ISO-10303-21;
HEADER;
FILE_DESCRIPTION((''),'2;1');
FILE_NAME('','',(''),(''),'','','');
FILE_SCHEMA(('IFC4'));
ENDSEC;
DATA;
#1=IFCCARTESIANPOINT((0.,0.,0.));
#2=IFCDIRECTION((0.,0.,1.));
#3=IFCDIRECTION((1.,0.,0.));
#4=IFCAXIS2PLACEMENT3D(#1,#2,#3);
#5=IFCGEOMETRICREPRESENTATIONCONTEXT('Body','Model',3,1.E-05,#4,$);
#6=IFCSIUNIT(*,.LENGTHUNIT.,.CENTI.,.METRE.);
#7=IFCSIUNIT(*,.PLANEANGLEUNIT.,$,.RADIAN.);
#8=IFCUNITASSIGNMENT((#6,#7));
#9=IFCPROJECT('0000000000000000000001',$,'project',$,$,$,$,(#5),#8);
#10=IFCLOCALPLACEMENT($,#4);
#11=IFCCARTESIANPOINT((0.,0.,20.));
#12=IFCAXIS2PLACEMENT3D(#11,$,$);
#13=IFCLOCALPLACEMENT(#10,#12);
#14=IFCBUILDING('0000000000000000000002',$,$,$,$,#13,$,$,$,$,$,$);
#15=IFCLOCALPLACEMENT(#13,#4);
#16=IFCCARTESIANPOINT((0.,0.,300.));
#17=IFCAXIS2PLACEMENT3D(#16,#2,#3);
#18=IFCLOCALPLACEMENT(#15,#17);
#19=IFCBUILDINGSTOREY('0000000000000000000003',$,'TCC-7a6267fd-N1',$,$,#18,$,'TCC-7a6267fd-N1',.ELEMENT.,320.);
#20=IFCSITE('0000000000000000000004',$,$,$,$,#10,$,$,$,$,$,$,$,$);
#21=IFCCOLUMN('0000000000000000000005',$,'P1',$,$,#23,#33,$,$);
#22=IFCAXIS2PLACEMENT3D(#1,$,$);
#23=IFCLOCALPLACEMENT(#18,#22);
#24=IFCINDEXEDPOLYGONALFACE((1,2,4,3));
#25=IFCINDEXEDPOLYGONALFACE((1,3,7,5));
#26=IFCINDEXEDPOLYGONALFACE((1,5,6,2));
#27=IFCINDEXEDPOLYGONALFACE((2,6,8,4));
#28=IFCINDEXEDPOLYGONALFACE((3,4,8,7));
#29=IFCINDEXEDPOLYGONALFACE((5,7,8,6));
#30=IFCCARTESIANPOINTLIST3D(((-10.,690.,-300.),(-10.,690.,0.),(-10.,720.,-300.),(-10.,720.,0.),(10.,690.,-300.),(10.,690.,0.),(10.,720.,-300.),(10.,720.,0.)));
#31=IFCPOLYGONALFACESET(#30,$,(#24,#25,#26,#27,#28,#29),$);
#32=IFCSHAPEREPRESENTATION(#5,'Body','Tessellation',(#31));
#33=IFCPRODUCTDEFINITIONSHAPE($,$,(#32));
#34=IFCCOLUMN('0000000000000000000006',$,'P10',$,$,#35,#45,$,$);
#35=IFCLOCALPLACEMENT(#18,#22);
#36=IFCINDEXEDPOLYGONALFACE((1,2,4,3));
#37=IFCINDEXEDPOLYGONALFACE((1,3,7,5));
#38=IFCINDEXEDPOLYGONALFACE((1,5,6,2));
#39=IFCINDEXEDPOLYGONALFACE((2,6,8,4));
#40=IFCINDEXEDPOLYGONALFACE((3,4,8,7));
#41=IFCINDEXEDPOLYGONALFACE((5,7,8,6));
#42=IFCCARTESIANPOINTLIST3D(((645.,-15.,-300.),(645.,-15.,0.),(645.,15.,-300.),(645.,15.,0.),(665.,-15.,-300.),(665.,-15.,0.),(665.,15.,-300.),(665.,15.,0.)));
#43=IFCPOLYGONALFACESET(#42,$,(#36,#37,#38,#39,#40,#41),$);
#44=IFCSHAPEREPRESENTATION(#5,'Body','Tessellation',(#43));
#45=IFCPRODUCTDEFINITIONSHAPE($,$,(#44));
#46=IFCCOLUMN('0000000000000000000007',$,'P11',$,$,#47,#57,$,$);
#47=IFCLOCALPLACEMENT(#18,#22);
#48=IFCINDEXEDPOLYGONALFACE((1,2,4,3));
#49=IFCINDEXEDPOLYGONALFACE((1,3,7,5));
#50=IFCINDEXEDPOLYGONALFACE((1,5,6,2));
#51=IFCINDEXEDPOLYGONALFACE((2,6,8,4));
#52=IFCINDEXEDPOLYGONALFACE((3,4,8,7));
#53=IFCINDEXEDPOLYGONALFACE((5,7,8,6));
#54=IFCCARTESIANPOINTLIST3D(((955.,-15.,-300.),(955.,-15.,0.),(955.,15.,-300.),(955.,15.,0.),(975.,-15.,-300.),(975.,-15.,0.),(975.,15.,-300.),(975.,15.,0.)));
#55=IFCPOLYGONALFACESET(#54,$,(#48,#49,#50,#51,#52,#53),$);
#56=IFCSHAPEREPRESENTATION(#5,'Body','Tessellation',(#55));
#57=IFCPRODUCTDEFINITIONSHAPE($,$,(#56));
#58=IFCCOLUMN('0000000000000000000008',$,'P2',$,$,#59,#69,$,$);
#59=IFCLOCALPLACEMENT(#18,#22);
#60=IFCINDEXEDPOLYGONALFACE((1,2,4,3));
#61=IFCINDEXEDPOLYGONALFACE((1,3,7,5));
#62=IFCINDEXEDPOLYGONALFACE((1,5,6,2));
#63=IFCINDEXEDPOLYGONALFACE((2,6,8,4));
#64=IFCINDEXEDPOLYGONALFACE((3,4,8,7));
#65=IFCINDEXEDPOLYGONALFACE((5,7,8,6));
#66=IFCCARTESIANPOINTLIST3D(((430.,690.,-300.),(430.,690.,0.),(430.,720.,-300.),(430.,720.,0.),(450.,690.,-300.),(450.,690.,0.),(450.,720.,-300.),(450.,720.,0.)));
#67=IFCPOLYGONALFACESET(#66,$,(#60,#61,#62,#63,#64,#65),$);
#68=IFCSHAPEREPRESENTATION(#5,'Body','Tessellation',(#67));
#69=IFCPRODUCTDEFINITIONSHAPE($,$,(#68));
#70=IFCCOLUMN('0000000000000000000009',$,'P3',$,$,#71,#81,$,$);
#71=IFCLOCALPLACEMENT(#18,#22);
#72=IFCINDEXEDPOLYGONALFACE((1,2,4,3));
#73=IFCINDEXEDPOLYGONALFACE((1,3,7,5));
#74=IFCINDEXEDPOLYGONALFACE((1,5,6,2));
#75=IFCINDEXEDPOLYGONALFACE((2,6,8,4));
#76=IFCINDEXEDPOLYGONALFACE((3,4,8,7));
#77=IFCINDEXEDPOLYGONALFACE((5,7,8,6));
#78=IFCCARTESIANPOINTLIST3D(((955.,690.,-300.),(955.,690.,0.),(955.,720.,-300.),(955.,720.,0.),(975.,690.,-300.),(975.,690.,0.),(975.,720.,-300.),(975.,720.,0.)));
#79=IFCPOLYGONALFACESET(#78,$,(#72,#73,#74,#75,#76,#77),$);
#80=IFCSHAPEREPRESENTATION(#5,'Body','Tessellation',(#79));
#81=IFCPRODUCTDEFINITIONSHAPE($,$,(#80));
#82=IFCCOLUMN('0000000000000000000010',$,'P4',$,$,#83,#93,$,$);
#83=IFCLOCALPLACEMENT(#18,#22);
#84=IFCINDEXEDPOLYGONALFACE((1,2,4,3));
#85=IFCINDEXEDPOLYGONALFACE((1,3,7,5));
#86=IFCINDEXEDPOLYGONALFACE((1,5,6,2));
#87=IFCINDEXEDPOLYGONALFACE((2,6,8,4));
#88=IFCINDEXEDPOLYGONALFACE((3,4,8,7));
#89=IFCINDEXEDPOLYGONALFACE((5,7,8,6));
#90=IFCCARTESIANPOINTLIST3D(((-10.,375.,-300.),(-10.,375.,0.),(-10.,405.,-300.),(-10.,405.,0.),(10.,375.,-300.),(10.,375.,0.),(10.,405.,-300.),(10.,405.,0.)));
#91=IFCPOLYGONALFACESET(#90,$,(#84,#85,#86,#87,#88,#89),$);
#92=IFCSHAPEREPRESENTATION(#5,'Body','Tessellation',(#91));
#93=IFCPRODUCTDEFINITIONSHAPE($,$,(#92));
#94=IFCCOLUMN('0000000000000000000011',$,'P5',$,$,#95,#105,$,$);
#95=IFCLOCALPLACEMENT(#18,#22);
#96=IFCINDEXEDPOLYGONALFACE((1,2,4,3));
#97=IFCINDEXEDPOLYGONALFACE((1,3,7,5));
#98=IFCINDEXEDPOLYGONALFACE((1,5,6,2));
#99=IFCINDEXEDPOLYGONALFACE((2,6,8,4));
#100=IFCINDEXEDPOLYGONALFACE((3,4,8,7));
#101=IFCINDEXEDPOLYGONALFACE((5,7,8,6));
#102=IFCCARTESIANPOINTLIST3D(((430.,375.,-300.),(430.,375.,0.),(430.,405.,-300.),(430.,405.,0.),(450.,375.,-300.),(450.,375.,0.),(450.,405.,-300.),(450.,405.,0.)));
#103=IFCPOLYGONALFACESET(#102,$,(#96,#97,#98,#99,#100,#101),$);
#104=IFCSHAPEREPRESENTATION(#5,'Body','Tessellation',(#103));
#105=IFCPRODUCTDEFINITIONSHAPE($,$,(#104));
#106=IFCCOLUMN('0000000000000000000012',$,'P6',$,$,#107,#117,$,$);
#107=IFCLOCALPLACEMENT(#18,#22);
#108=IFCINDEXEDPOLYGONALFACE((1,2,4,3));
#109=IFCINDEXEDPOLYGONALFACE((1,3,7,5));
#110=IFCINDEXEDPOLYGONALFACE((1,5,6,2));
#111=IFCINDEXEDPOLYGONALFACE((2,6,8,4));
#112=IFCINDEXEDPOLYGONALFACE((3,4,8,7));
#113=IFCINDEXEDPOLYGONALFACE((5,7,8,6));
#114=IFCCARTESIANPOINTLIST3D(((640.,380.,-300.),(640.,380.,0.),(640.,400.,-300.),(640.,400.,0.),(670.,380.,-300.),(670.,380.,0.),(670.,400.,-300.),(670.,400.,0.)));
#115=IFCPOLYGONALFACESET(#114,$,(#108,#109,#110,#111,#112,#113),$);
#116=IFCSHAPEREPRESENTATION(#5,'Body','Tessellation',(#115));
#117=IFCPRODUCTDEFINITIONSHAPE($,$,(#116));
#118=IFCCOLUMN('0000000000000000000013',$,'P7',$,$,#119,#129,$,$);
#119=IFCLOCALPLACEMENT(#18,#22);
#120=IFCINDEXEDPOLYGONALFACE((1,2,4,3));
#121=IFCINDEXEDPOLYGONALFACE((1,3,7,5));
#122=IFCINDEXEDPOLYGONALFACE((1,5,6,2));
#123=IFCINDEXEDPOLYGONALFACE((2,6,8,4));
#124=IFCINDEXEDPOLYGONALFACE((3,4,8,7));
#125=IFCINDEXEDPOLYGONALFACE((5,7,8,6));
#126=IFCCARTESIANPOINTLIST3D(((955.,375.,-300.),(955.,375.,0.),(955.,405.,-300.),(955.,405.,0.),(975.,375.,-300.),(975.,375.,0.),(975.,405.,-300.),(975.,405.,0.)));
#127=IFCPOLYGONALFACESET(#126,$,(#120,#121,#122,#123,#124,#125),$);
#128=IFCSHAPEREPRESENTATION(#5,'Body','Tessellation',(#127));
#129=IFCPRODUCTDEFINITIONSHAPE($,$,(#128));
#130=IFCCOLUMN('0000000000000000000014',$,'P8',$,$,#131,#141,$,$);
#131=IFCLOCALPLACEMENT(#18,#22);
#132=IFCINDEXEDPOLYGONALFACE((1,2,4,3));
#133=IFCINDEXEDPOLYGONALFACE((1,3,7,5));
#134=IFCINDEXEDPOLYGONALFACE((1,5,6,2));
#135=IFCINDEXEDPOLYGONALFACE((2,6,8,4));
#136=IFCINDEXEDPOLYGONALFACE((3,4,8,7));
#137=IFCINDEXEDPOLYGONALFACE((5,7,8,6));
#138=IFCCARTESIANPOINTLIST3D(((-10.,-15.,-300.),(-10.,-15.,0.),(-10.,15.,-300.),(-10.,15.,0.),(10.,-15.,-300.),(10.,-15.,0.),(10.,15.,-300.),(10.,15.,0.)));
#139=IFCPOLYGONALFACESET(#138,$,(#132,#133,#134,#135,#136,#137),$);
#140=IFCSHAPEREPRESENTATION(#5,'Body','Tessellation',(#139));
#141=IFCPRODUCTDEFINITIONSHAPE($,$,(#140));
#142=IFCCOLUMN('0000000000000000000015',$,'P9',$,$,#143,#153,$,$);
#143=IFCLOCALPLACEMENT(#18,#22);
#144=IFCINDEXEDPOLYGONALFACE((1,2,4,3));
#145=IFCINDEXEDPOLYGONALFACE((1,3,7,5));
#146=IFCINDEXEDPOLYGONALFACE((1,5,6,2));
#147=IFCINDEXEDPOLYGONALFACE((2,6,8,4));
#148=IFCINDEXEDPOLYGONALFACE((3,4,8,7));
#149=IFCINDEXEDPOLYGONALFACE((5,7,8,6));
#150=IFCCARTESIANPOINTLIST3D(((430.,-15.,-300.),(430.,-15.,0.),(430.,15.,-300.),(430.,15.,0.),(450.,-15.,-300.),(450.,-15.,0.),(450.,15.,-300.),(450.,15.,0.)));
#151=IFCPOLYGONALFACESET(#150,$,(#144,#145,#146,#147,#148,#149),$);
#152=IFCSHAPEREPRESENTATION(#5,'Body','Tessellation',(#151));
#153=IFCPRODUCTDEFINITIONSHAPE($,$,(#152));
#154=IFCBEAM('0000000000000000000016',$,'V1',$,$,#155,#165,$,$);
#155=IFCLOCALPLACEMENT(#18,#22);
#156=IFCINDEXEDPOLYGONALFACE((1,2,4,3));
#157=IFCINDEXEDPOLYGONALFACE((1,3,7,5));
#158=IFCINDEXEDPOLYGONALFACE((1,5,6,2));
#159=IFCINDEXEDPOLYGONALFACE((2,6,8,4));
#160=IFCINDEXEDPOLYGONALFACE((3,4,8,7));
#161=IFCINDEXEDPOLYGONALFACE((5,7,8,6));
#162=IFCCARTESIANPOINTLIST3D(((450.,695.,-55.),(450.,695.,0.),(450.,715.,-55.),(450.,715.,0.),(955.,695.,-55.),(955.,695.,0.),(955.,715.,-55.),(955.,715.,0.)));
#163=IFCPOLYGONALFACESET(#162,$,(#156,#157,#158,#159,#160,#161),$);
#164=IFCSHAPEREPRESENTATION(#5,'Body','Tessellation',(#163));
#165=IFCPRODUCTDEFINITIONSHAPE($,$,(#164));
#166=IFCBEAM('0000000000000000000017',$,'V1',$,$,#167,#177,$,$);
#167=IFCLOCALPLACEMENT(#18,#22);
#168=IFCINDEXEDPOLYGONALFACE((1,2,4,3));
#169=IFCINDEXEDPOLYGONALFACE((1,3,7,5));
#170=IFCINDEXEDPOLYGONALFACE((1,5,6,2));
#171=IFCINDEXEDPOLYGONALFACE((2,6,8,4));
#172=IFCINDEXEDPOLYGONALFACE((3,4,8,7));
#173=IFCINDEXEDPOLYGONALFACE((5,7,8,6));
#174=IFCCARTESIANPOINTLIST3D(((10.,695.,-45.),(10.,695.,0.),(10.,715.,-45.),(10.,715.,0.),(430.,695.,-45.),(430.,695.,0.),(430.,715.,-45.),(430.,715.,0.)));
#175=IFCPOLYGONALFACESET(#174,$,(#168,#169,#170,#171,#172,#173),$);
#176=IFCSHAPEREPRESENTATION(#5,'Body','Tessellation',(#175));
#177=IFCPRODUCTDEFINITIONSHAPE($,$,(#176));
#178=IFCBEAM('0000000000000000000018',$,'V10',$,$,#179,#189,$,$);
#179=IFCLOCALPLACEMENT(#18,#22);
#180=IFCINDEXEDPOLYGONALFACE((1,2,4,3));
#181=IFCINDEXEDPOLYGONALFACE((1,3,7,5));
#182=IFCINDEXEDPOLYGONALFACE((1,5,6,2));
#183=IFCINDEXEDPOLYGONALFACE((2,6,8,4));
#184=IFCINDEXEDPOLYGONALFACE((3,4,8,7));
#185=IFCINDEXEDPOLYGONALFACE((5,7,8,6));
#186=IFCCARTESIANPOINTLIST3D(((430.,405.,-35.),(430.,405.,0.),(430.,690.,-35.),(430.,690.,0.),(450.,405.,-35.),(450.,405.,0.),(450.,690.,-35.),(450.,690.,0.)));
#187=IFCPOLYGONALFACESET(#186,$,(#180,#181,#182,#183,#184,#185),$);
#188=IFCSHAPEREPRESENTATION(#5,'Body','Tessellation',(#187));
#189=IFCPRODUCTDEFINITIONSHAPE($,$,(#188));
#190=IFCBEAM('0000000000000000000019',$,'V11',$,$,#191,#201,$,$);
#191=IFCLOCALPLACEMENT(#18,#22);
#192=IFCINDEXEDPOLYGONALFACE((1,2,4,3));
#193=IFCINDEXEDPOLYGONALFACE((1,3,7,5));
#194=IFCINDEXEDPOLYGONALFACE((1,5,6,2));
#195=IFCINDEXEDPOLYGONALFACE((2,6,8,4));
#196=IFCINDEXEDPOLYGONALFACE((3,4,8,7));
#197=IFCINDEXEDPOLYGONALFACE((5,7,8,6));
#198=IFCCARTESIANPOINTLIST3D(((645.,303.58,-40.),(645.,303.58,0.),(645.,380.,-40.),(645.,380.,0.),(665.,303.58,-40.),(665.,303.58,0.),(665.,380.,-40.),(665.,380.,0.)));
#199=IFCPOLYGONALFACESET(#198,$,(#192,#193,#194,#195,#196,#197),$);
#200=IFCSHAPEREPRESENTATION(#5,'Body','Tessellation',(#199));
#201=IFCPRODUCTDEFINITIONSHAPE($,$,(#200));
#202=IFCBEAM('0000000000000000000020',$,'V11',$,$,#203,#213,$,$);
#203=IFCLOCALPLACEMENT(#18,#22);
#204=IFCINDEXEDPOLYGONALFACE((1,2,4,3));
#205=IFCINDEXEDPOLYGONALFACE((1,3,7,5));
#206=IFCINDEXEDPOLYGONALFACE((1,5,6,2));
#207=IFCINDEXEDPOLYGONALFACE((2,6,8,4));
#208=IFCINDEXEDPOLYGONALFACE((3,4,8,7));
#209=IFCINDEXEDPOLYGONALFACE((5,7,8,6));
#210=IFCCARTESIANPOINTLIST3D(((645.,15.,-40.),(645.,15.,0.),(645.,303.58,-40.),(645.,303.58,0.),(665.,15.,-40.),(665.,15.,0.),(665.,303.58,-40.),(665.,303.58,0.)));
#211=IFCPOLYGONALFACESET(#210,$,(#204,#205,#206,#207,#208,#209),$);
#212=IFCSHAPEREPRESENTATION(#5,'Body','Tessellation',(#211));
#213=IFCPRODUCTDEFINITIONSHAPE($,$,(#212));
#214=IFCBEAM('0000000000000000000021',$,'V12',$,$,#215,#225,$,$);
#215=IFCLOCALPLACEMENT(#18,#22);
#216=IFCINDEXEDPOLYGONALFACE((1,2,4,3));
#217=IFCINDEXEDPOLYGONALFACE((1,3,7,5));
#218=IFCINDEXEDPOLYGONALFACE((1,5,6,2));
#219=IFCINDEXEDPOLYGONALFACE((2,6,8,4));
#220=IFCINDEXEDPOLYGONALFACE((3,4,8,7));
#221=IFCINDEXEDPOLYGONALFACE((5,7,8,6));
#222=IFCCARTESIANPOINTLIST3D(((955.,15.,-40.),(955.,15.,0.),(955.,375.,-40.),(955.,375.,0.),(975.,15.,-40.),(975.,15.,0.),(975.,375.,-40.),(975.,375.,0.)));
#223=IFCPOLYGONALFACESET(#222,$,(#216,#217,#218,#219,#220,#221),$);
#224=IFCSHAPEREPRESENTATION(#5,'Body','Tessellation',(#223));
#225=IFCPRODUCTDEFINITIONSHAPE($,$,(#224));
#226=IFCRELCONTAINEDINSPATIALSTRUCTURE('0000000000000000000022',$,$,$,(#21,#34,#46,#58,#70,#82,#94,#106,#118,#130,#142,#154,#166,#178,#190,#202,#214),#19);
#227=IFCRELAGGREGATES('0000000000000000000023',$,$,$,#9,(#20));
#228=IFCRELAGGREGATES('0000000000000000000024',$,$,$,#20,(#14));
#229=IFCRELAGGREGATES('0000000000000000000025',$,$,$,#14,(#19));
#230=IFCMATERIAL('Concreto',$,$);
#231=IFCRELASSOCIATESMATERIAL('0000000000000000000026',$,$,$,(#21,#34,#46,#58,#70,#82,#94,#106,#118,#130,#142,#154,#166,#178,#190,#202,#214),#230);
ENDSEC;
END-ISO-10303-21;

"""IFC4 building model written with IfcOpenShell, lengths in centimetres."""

from ifc_helpers import new_model, si_unit, frame, origin_with_axes, origin_2d_with_axis, place, context, project, spatial, rectangle, extrude, material, element, save


model = new_model("IFC4")

# Units and contexts
model_context = context("Model", 3, precision=1e-05, world=origin_with_axes(), identifier="Body")
ifc_project = project(units=[si_unit("LENGTHUNIT", "METRE", prefix="CENTI"), si_unit("PLANEANGLEUNIT", "RADIAN")], contexts=[model_context])

# Site, building, storey
site_placement = place(None, origin_with_axes())
site = spatial("IfcSite", under=ifc_project, at=site_placement)
building_placement = place(site_placement, frame((0.0, 0.0, 20.0)))
building = spatial("IfcBuilding", under=site, at=building_placement)
placement = place(building_placement, origin_with_axes())
storey_placement = place(placement, frame((0.0, 0.0, 300.0), z_axis=(0.0, 0.0, 1.0), x_axis=(1.0, 0.0, 0.0)))
storey = spatial("IfcBuildingStorey", under=building, at=storey_placement, Name="TCC-7a6267fd-N1", LongName="TCC-7a6267fd-N1", CompositionType="ELEMENT", Elevation=320.0)

# Columns
ifc_material = material(Name="Concreto")
for number, where, z_axis, x_axis, name in (
    (1, (0.0, 705.0, 0.0), (0.0, 0.0, 1.0), (1.0, 0.0, 0.0), "P1"),
    (2, (655.0, 0.0, 0.0), (0.0, 0.0, 1.0), (1.0, 0.0, 0.0), "P10"),
    (3, (965.0, 0.0, 0.0), (0.0, 0.0, 1.0), (1.0, 0.0, 0.0), "P11"),
    (4, (440.0, 705.0, 0.0), (0.0, 0.0, 1.0), (1.0, 0.0, 0.0), "P2"),
    (5, (965.0, 705.0, 0.0), (0.0, 0.0, 1.0), (1.0, 0.0, 0.0), "P3"),
    (6, (0.0, 390.0, 0.0), (0.0, 0.0, 1.0), (1.0, 0.0, 0.0), "P4"),
    (7, (440.0, 390.0, 0.0), (0.0, 0.0, 1.0), (1.0, 0.0, 0.0), "P5"),
):
    element("IfcColumn", number, at=place(storey_placement, frame(where, z_axis=z_axis, x_axis=x_axis)), inside=storey, material=ifc_material, Name=name, context=model_context, shape_type="SolidModel", body=[
        extrude(rectangle(XDim=20.0, YDim=30.0, at=origin_2d_with_axis()), origin_with_axes(), (0.0, 0.0, -1.0), 300.0),
    ])
column_placement = place(storey_placement, frame((655.0, 390.0, 0.0), z_axis=(0.0, 0.0, 1.0), x_axis=(1.0, 0.0, 0.0)))
element("IfcColumn", 8, at=column_placement, inside=storey, material=ifc_material, Name="P6", context=model_context, shape_type="SolidModel", body=[
    extrude(rectangle(XDim=20.0, YDim=30.0, at=origin_2d_with_axis()), frame((0.0, 0.0, 0.0), z_axis=(0.0, 0.0, 1.0), x_axis=(0.0, 1.0, 0.0)), (0.0, 0.0, -1.0), 300.0),
])
for number, where, z_axis, x_axis, name in (
    (9, (965.0, 390.0, 0.0), (0.0, 0.0, 1.0), (1.0, 0.0, 0.0), "P7"),
    (10, (0.0, 0.0, 0.0), (0.0, 0.0, 1.0), (1.0, 0.0, 0.0), "P8"),
    (11, (440.0, 0.0, 0.0), (0.0, 0.0, 1.0), (1.0, 0.0, 0.0), "P9"),
):
    element("IfcColumn", number, at=place(storey_placement, frame(where, z_axis=z_axis, x_axis=x_axis)), inside=storey, material=ifc_material, Name=name, context=model_context, shape_type="SolidModel", body=[
        extrude(rectangle(XDim=20.0, YDim=30.0, at=origin_2d_with_axis()), origin_with_axes(), (0.0, 0.0, -1.0), 300.0),
    ])

# Beams
beam_1_placement = place(storey_placement, frame((702.5, 705.0, 0.0), z_axis=(0.0, 0.0, 1.0), x_axis=(1.0, 0.0, 0.0)))
element("IfcBeam", 12, at=beam_1_placement, inside=storey, material=ifc_material, Name="V1", context=model_context, shape_type="SolidModel", body=[
    extrude(rectangle(XDim=20.0, YDim=55.0, at=origin_2d_with_axis()), frame((252.5, 0.0, -27.5), z_axis=(-1.0, 0.0, 0.0), x_axis=(0.0, 1.0, 0.0)), (0.0, 0.0, 1.0), 505.0),
])
beam_2_placement = place(storey_placement, frame((220.0, 705.0, 0.0), z_axis=(0.0, 0.0, 1.0), x_axis=(1.0, 0.0, 0.0)))
element("IfcBeam", 13, at=beam_2_placement, inside=storey, material=ifc_material, Name="V1", context=model_context, shape_type="SolidModel", body=[
    extrude(rectangle(XDim=20.0, YDim=45.0, at=origin_2d_with_axis()), frame((210.0, 0.0, -22.5), z_axis=(-1.0, 0.0, 0.0), x_axis=(0.0, 1.0, 0.0)), (0.0, 0.0, 1.0), 420.0),
])
beam_3_placement = place(storey_placement, frame((440.0, 547.5, 0.0), z_axis=(0.0, 0.0, 1.0), x_axis=(1.0, 0.0, 0.0)))
element("IfcBeam", 14, at=beam_3_placement, inside=storey, material=ifc_material, Name="V10", context=model_context, shape_type="SolidModel", body=[
    extrude(rectangle(XDim=20.0, YDim=35.0, at=origin_2d_with_axis()), frame((0.0, 142.5, -17.5), z_axis=(0.0, -1.0, 0.0), x_axis=(1.0, 0.0, 0.0)), (0.0, 0.0, 1.0), 285.0),
])
beam_4_placement = place(storey_placement, frame((655.0, 341.79, 0.0), z_axis=(0.0, 0.0, 1.0), x_axis=(1.0, 0.0, 0.0)))
element("IfcBeam", 15, at=beam_4_placement, inside=storey, material=ifc_material, Name="V11", context=model_context, shape_type="SolidModel", body=[
    extrude(rectangle(XDim=20.0, YDim=40.0, at=origin_2d_with_axis()), frame((0.0, -38.21, -20.0), z_axis=(0.0, 1.0, 0.0), x_axis=(1.0, 0.0, 0.0)), (0.0, 0.0, 1.0), 76.42),
])
beam_5_placement = place(storey_placement, frame((655.0, 159.29, 0.0), z_axis=(0.0, 0.0, 1.0), x_axis=(1.0, 0.0, 0.0)))
element("IfcBeam", 16, at=beam_5_placement, inside=storey, material=ifc_material, Name="V11", context=model_context, shape_type="SolidModel", body=[
    extrude(rectangle(XDim=20.0, YDim=40.0, at=origin_2d_with_axis()), frame((0.0, -144.29, -20.0), z_axis=(0.0, 1.0, 0.0), x_axis=(1.0, 0.0, 0.0)), (0.0, 0.0, 1.0), 288.58),
])
beam_6_placement = place(storey_placement, frame((965.0, 195.0, 0.0), z_axis=(0.0, 0.0, 1.0), x_axis=(1.0, 0.0, 0.0)))
element("IfcBeam", 17, at=beam_6_placement, inside=storey, material=ifc_material, Name="V12", context=model_context, shape_type="SolidModel", body=[
    extrude(rectangle(XDim=20.0, YDim=40.0, at=origin_2d_with_axis()), frame((0.0, -180.0, -20.0), z_axis=(0.0, 1.0, 0.0), x_axis=(1.0, 0.0, 0.0)), (0.0, 0.0, 1.0), 360.0),
])

save(model, "model.ifc")
